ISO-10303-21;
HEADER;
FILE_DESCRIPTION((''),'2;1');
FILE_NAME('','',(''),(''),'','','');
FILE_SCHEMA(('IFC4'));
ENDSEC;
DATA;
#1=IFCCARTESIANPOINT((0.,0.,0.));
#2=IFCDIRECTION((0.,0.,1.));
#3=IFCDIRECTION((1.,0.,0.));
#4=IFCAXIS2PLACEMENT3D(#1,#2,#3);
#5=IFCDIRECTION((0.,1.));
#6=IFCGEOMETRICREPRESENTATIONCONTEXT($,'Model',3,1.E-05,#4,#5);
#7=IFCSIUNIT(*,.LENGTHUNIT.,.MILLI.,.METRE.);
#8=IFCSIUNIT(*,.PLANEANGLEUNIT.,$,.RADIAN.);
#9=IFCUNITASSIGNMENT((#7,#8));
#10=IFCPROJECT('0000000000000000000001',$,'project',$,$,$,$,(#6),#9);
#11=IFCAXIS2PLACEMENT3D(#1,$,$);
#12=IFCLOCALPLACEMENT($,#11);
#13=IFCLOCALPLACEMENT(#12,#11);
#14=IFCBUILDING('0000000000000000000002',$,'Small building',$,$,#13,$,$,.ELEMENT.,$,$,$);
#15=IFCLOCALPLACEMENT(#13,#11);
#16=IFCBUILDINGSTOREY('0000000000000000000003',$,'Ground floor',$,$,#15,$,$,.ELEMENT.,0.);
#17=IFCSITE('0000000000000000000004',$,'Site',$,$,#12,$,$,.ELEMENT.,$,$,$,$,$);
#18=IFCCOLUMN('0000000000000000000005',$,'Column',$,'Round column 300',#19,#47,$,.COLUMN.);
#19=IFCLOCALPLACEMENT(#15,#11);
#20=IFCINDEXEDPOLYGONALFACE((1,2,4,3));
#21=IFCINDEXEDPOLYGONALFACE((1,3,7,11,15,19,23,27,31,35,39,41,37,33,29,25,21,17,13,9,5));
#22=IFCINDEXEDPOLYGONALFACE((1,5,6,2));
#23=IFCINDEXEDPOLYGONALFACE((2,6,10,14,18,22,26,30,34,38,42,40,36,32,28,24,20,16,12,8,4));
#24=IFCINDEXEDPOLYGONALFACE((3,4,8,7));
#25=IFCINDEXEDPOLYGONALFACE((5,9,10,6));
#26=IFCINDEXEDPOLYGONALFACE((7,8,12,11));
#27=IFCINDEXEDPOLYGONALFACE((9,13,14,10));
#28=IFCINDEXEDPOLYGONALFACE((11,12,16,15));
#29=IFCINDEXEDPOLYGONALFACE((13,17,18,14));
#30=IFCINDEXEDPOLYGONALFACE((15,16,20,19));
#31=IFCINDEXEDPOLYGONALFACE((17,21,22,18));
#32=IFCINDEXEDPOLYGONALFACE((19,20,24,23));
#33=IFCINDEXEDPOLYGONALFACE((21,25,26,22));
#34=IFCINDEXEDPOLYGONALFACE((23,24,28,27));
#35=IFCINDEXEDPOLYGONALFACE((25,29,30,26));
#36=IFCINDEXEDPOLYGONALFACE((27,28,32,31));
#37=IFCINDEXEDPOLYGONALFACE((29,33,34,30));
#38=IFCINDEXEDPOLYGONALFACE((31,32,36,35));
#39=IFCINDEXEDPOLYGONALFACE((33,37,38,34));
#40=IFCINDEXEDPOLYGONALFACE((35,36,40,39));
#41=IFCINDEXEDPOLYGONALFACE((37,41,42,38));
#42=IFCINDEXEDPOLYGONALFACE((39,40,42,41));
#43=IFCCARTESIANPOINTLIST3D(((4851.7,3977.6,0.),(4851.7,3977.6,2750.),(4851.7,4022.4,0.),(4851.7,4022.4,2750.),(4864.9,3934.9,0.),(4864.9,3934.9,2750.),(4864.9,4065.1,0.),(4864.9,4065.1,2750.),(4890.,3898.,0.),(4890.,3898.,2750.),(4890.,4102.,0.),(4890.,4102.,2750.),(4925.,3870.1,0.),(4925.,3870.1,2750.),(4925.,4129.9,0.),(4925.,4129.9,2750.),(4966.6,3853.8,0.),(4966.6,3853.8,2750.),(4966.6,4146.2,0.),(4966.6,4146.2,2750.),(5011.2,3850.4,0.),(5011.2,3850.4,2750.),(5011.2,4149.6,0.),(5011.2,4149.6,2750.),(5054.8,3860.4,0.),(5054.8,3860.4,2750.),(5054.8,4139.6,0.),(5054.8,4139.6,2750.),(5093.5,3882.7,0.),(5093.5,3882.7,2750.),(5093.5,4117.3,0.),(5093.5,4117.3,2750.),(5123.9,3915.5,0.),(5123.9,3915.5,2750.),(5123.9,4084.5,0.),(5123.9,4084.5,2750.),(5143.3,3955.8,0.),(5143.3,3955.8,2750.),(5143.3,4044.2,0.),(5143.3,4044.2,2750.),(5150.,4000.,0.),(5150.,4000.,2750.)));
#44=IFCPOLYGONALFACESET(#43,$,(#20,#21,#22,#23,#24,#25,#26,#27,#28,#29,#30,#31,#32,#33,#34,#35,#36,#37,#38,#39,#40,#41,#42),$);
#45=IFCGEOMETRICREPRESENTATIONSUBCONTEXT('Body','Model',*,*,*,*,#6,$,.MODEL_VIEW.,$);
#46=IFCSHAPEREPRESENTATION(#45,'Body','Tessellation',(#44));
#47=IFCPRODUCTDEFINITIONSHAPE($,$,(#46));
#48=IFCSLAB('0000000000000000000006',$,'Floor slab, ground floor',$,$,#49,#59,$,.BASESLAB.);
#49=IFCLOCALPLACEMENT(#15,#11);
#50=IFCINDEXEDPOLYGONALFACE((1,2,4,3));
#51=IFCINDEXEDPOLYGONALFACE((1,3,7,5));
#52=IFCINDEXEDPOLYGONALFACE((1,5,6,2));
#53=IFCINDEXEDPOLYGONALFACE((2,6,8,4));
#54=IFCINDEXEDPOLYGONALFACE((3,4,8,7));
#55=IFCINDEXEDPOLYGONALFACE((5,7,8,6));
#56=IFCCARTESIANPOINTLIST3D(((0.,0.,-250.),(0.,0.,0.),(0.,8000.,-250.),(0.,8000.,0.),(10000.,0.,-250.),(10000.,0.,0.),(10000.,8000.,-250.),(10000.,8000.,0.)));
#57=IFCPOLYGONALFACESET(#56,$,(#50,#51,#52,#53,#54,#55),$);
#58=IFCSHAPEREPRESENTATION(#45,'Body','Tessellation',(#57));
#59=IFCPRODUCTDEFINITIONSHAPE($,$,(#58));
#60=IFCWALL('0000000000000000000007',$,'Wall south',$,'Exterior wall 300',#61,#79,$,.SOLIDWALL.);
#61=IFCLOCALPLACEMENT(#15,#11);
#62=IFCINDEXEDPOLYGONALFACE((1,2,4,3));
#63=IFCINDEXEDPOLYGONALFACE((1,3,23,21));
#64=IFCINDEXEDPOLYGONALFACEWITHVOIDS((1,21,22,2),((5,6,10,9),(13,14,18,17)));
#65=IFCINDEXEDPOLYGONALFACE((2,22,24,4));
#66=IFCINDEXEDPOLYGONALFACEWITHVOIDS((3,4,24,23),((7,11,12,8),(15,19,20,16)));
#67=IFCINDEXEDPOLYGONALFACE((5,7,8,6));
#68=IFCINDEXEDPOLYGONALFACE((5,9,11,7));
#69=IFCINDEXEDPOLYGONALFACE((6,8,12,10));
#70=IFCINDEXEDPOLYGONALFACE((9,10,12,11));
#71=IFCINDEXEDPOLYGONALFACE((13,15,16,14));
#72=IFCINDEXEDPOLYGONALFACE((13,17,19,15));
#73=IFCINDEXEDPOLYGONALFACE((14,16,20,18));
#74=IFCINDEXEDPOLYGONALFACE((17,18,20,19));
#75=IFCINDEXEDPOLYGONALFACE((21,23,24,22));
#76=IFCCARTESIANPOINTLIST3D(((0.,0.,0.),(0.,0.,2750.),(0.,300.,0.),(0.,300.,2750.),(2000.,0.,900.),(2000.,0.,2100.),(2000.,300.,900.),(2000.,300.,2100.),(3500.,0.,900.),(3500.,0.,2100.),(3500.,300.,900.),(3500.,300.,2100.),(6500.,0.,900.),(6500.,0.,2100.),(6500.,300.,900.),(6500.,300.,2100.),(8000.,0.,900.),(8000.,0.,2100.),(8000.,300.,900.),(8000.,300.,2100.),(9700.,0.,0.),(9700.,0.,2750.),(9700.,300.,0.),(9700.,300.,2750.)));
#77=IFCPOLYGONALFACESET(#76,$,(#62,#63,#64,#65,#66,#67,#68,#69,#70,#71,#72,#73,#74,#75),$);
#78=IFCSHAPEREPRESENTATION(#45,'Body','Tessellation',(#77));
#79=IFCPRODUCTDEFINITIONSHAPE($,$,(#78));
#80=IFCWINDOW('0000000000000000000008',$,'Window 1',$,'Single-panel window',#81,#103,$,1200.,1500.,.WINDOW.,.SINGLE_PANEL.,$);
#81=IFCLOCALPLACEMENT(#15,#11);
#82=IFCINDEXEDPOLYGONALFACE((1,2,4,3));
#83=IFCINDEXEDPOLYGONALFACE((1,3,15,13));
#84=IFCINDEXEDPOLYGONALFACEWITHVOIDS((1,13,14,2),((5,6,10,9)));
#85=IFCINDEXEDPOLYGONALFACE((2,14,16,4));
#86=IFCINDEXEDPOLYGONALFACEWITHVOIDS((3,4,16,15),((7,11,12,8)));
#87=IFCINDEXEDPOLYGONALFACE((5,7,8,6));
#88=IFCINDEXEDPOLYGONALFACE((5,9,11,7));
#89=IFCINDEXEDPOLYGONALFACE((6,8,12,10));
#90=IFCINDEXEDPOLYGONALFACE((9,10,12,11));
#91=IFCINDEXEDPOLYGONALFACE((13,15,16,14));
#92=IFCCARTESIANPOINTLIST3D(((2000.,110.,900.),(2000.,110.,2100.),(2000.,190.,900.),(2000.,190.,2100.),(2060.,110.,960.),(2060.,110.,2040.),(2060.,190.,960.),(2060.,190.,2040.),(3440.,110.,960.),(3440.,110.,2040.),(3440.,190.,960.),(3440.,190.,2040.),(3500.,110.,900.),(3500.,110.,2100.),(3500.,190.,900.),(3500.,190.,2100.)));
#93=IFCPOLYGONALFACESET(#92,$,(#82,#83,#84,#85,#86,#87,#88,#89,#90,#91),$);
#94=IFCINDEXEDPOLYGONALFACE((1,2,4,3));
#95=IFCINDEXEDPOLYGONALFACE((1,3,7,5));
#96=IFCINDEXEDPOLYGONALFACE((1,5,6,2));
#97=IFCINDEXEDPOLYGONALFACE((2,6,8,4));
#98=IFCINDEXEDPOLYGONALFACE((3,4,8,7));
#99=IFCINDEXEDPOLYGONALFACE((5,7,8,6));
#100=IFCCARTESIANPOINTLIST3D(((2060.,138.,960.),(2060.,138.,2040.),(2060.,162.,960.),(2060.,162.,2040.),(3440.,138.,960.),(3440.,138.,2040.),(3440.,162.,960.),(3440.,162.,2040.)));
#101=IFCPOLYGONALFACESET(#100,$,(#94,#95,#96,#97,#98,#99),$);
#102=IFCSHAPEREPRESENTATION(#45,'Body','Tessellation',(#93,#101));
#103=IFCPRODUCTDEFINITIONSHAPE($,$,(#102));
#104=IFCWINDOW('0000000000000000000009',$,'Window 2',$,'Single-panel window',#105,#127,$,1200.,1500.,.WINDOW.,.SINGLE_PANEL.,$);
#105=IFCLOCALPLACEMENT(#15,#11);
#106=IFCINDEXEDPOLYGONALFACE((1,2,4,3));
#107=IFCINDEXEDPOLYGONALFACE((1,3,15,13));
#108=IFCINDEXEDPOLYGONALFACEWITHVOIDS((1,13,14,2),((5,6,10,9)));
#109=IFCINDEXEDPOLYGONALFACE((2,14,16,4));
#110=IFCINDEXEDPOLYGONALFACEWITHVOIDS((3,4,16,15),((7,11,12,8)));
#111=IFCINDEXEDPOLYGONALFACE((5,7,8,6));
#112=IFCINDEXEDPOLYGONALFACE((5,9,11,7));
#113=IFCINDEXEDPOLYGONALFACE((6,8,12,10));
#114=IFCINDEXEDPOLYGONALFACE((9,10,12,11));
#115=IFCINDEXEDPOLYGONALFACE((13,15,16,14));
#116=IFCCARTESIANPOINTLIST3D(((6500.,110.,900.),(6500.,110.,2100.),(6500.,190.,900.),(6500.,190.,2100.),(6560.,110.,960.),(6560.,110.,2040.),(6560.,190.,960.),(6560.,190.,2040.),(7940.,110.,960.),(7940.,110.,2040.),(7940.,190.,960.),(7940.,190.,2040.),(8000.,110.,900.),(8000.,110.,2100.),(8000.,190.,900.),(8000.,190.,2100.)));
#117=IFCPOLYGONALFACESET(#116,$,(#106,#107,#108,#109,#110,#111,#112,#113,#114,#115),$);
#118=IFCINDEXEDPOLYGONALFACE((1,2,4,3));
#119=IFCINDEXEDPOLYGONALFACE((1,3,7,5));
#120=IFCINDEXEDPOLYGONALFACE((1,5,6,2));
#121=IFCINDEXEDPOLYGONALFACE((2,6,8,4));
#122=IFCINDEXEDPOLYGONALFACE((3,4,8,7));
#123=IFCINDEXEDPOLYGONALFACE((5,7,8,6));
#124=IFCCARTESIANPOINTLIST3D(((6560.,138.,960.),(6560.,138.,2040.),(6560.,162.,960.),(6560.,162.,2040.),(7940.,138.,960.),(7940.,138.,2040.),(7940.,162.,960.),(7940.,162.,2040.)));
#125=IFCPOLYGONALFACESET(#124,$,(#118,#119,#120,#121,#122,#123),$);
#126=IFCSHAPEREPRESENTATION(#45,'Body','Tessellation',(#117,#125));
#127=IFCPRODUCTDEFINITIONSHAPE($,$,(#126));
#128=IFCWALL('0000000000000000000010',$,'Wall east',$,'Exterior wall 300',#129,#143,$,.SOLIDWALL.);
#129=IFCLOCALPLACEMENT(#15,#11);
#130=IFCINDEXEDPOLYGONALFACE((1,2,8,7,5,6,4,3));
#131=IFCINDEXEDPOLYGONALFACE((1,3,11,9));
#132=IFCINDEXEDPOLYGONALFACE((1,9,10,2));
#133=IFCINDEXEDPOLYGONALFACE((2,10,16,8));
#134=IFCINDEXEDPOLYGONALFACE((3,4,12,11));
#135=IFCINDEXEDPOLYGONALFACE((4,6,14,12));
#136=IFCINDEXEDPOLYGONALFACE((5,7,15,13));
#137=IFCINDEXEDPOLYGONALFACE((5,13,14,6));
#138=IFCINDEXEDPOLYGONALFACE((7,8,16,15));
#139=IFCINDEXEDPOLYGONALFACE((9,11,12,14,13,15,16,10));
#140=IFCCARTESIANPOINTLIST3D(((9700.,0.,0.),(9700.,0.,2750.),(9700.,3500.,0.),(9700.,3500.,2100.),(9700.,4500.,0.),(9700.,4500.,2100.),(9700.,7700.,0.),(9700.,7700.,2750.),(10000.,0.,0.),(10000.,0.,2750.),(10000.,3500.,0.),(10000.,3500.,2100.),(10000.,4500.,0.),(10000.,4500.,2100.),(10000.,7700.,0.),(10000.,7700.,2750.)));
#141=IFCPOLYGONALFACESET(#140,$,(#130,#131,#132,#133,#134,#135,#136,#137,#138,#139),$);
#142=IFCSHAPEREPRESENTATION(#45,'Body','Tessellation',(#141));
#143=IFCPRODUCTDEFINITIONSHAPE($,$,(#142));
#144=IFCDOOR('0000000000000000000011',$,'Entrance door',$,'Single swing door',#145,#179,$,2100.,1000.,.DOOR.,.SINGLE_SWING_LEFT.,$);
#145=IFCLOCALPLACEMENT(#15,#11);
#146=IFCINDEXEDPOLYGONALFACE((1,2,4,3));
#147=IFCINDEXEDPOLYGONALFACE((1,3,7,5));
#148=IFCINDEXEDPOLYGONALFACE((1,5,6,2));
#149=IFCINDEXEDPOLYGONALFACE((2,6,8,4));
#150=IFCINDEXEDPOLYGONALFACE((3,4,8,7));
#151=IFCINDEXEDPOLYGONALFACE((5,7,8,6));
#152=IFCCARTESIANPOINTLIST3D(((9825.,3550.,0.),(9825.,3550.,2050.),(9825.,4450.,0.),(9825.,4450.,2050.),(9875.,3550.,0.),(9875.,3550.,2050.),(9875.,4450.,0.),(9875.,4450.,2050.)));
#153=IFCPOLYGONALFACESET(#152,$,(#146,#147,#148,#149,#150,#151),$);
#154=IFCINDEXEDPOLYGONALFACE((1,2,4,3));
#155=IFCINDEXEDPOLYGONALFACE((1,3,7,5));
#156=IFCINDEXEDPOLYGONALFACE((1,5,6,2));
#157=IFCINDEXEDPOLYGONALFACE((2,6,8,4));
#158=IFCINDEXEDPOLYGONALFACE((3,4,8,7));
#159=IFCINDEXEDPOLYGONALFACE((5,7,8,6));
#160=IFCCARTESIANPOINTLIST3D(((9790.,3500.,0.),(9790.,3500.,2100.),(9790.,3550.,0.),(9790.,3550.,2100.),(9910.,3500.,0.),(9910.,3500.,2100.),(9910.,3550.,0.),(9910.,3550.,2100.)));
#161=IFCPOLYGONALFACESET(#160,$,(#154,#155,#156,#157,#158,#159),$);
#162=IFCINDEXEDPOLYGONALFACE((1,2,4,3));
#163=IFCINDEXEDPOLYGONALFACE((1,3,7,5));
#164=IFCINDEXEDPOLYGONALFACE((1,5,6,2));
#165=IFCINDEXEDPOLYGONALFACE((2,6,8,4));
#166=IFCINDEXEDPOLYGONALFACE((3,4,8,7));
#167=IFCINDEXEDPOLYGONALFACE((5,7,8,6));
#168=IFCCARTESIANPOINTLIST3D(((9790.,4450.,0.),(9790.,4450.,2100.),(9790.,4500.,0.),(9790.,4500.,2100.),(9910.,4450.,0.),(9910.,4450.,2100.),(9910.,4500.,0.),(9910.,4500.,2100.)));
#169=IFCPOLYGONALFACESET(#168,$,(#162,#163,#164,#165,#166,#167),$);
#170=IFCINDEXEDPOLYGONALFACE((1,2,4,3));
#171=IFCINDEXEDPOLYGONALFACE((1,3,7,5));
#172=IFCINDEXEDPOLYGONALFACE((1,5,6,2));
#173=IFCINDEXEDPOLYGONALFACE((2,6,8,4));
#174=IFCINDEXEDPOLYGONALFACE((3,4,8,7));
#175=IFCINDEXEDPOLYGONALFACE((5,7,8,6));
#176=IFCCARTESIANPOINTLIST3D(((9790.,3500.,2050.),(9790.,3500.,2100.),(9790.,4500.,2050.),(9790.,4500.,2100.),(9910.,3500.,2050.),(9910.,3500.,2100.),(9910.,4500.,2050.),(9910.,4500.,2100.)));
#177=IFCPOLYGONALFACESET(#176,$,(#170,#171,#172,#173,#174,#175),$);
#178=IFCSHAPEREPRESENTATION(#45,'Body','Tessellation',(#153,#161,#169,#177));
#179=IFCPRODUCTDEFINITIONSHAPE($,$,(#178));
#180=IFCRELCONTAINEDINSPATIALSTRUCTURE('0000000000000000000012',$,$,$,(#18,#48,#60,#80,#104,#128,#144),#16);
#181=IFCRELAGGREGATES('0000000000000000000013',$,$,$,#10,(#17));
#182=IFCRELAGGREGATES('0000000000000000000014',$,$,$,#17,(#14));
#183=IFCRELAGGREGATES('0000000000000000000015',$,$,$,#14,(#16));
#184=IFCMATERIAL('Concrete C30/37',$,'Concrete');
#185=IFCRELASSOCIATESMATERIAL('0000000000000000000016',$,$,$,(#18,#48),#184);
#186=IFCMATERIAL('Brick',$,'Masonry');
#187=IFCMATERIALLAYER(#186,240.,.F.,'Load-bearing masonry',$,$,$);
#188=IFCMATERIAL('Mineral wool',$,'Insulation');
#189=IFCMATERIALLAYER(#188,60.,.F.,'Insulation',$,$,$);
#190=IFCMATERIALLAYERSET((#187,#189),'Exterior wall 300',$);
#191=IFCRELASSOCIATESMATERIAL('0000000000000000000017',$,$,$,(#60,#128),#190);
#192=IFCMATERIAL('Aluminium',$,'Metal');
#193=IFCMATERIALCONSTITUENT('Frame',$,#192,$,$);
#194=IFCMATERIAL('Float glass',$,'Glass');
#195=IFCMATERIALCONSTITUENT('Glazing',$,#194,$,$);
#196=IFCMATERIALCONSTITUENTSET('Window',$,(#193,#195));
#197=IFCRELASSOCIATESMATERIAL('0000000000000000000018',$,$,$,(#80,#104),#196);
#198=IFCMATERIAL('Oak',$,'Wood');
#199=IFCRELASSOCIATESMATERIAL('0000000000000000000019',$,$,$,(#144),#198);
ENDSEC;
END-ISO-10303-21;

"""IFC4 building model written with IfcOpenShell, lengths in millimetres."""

from ifc_helpers import new_model, si_unit, direction, frame, frame_2d, origin, origin_with_axes, origin_2d, place, context, subcontext, project, spatial, rectangle, hollow_rectangle, circle, extrude, material, layer, layer_set, layer_usage, constituent, constituent_set, element, fill, save


model = new_model("IFC4")

# Units and contexts
model_context = context("Model", 3, precision=1e-05, world=origin_with_axes(), true_north=direction((0.0, 1.0)))
body_context = subcontext(model_context, "Body", "Model", "MODEL_VIEW")
ifc_project = project(units=[si_unit("LENGTHUNIT", "METRE", prefix="MILLI"), si_unit("PLANEANGLEUNIT", "RADIAN")], contexts=[model_context])

# Site, building, storey
site_placement = place(None, origin())
site = spatial("IfcSite", under=ifc_project, at=site_placement, Name="Site", CompositionType="ELEMENT")
building_placement = place(site_placement, origin())
building = spatial("IfcBuilding", under=site, at=building_placement, Name="Small building", CompositionType="ELEMENT")
storey_placement = place(building_placement, origin())
storey = spatial("IfcBuildingStorey", under=building, at=storey_placement, Name="Ground floor", CompositionType="ELEMENT", Elevation=0.0)

# Column
ifc_material_1 = material(Name="Concrete C30/37", Category="Concrete")
column_placement = place(storey_placement, frame((5000.0, 4000.0, 0.0)))
element("IfcColumn", 1, at=column_placement, inside=storey, material=ifc_material_1, Name="Column", ObjectType="Round column 300", PredefinedType="COLUMN", context=body_context, shape_type="SweptSolid", body=[
    extrude(circle(Radius=150.0, at=origin_2d()), origin_with_axes(), (0.0, 0.0, 1.0), 2750.0),
])

# Slab
slab_placement = place(storey_placement, frame((0.0, 0.0, -250.0)))
element("IfcSlab", 2, at=slab_placement, inside=storey, material=ifc_material_1, Name="Floor slab, ground floor", PredefinedType="BASESLAB", context=body_context, shape_type="SweptSolid", body=[
    extrude(rectangle(XDim=10000.0, YDim=8000.0, at=frame_2d((5000.0, 4000.0))), origin_with_axes(), (0.0, 0.0, 1.0), 250.0),
])

# Wall, openings, windows
ifc_material_2 = material(Name="Brick", Category="Masonry")
ifc_layer_1 = layer(ifc_material_2, 240.0, ventilated=False, Name="Load-bearing masonry")
ifc_material_3 = material(Name="Mineral wool", Category="Insulation")
ifc_layer_2 = layer(ifc_material_3, 60.0, ventilated=False, Name="Insulation")
ifc_layer_set = layer_set([ifc_layer_1, ifc_layer_2], Name="Exterior wall 300")
ifc_layer_usage_1 = layer_usage(ifc_layer_set, "AXIS2", "POSITIVE", 0.0)
wall_1_placement = place(storey_placement, frame((0.0, 0.0, 0.0), x_axis=(1.0, 0.0, 0.0)))
wall_1 = element("IfcWall", 3, at=wall_1_placement, inside=storey, material=ifc_layer_usage_1, Name="Wall south", ObjectType="Exterior wall 300", PredefinedType="SOLIDWALL", context=body_context, shape_type="SweptSolid", body=[
    extrude(rectangle(XDim=9700.0, YDim=300.0, at=frame_2d((4850.0, 150.0))), origin_with_axes(), (0.0, 0.0, 1.0), 2750.0),
])
opening_1_placement = place(wall_1_placement, frame((2000.0, 0.0, 900.0)))
opening_1 = element("IfcOpeningElement", 4, at=opening_1_placement, cuts=wall_1, PredefinedType="OPENING", context=body_context, shape_type="SweptSolid", body=[
    extrude(rectangle(XDim=1500.0, YDim=400.0, at=frame_2d((750.0, 150.0))), origin_with_axes(), (0.0, 0.0, 1.0), 1200.0),
])
opening_2_placement = place(wall_1_placement, frame((6500.0, 0.0, 900.0)))
opening_2 = element("IfcOpeningElement", 5, at=opening_2_placement, cuts=wall_1, PredefinedType="OPENING", context=body_context, shape_type="SweptSolid", body=[
    extrude(rectangle(XDim=1500.0, YDim=400.0, at=frame_2d((750.0, 150.0))), origin_with_axes(), (0.0, 0.0, 1.0), 1200.0),
])
ifc_material_4 = material(Name="Aluminium", Category="Metal")
ifc_constituent_1 = constituent(ifc_material_4, Name="Frame")
ifc_material_5 = material(Name="Float glass", Category="Glass")
ifc_constituent_2 = constituent(ifc_material_5, Name="Glazing")
ifc_constituent_set = constituent_set(constituents=[ifc_constituent_1, ifc_constituent_2], Name="Window")
window_1_placement = place(opening_1_placement, origin())
window_1 = element("IfcWindow", 6, at=window_1_placement, inside=storey, material=ifc_constituent_set, Name="Window 1", ObjectType="Single-panel window", OverallHeight=1200.0, OverallWidth=1500.0, PartitioningType="SINGLE_PANEL", PredefinedType="WINDOW", context=body_context, shape_type="SweptSolid", body=[
    extrude(hollow_rectangle(XDim=1500.0, YDim=1200.0, WallThickness=60.0, at=origin_2d()), frame((750.0, 110.0, 600.0), z_axis=(0.0, 1.0, 0.0), x_axis=(1.0, 0.0, 0.0)), (0.0, 0.0, 1.0), 80.0),
    extrude(rectangle(XDim=1380.0, YDim=1080.0, at=origin_2d()), frame((750.0, 138.0, 600.0), z_axis=(0.0, 1.0, 0.0), x_axis=(1.0, 0.0, 0.0)), (0.0, 0.0, 1.0), 24.0),
])
fill(opening_1, window_1)
window_2_placement = place(opening_2_placement, origin())
window_2 = element("IfcWindow", 7, at=window_2_placement, inside=storey, material=ifc_constituent_set, Name="Window 2", ObjectType="Single-panel window", OverallHeight=1200.0, OverallWidth=1500.0, PartitioningType="SINGLE_PANEL", PredefinedType="WINDOW", context=body_context, shape_type="SweptSolid", body=[
    extrude(hollow_rectangle(XDim=1500.0, YDim=1200.0, WallThickness=60.0, at=origin_2d()), frame((750.0, 110.0, 600.0), z_axis=(0.0, 1.0, 0.0), x_axis=(1.0, 0.0, 0.0)), (0.0, 0.0, 1.0), 80.0),
    extrude(rectangle(XDim=1380.0, YDim=1080.0, at=origin_2d()), frame((750.0, 138.0, 600.0), z_axis=(0.0, 1.0, 0.0), x_axis=(1.0, 0.0, 0.0)), (0.0, 0.0, 1.0), 24.0),
])
fill(opening_2, window_2)

# Wall, opening, door
ifc_layer_usage_2 = layer_usage(ifc_layer_set, "AXIS2", "POSITIVE", 0.0)
wall_2_placement = place(storey_placement, frame((10000.0, 0.0, 0.0), x_axis=(0.0, 1.0, 0.0)))
wall_2 = element("IfcWall", 8, at=wall_2_placement, inside=storey, material=ifc_layer_usage_2, Name="Wall east", ObjectType="Exterior wall 300", PredefinedType="SOLIDWALL", context=body_context, shape_type="SweptSolid", body=[
    extrude(rectangle(XDim=7700.0, YDim=300.0, at=frame_2d((3850.0, 150.0))), origin_with_axes(), (0.0, 0.0, 1.0), 2750.0),
])
opening_3_placement = place(wall_2_placement, frame((3500.0, 0.0, 0.0)))
opening_3 = element("IfcOpeningElement", 9, at=opening_3_placement, cuts=wall_2, PredefinedType="OPENING", context=body_context, shape_type="SweptSolid", body=[
    extrude(rectangle(XDim=1000.0, YDim=400.0, at=frame_2d((500.0, 150.0))), origin_with_axes(), (0.0, 0.0, 1.0), 2100.0),
])
ifc_material_6 = material(Name="Oak", Category="Wood")
door_placement = place(opening_3_placement, origin())
door = element("IfcDoor", 10, at=door_placement, inside=storey, material=ifc_material_6, Name="Entrance door", ObjectType="Single swing door", OperationType="SINGLE_SWING_LEFT", OverallHeight=2100.0, OverallWidth=1000.0, PredefinedType="DOOR", context=body_context, shape_type="SweptSolid", body=[
    extrude(rectangle(XDim=900.0, YDim=2050.0, at=origin_2d()), frame((500.0, 125.0, 1025.0), z_axis=(0.0, 1.0, 0.0), x_axis=(1.0, 0.0, 0.0)), (0.0, 0.0, 1.0), 50.0),
    extrude(rectangle(XDim=50.0, YDim=2100.0, at=origin_2d()), frame((25.0, 90.0, 1050.0), z_axis=(0.0, 1.0, 0.0), x_axis=(1.0, 0.0, 0.0)), (0.0, 0.0, 1.0), 120.0),
    extrude(rectangle(XDim=50.0, YDim=2100.0, at=origin_2d()), frame((975.0, 90.0, 1050.0), z_axis=(0.0, 1.0, 0.0), x_axis=(1.0, 0.0, 0.0)), (0.0, 0.0, 1.0), 120.0),
    extrude(rectangle(XDim=1000.0, YDim=50.0, at=origin_2d()), frame((500.0, 90.0, 2075.0), z_axis=(0.0, 1.0, 0.0), x_axis=(1.0, 0.0, 0.0)), (0.0, 0.0, 1.0), 120.0),
])
fill(opening_3, door)

save(model, "model.ifc")
